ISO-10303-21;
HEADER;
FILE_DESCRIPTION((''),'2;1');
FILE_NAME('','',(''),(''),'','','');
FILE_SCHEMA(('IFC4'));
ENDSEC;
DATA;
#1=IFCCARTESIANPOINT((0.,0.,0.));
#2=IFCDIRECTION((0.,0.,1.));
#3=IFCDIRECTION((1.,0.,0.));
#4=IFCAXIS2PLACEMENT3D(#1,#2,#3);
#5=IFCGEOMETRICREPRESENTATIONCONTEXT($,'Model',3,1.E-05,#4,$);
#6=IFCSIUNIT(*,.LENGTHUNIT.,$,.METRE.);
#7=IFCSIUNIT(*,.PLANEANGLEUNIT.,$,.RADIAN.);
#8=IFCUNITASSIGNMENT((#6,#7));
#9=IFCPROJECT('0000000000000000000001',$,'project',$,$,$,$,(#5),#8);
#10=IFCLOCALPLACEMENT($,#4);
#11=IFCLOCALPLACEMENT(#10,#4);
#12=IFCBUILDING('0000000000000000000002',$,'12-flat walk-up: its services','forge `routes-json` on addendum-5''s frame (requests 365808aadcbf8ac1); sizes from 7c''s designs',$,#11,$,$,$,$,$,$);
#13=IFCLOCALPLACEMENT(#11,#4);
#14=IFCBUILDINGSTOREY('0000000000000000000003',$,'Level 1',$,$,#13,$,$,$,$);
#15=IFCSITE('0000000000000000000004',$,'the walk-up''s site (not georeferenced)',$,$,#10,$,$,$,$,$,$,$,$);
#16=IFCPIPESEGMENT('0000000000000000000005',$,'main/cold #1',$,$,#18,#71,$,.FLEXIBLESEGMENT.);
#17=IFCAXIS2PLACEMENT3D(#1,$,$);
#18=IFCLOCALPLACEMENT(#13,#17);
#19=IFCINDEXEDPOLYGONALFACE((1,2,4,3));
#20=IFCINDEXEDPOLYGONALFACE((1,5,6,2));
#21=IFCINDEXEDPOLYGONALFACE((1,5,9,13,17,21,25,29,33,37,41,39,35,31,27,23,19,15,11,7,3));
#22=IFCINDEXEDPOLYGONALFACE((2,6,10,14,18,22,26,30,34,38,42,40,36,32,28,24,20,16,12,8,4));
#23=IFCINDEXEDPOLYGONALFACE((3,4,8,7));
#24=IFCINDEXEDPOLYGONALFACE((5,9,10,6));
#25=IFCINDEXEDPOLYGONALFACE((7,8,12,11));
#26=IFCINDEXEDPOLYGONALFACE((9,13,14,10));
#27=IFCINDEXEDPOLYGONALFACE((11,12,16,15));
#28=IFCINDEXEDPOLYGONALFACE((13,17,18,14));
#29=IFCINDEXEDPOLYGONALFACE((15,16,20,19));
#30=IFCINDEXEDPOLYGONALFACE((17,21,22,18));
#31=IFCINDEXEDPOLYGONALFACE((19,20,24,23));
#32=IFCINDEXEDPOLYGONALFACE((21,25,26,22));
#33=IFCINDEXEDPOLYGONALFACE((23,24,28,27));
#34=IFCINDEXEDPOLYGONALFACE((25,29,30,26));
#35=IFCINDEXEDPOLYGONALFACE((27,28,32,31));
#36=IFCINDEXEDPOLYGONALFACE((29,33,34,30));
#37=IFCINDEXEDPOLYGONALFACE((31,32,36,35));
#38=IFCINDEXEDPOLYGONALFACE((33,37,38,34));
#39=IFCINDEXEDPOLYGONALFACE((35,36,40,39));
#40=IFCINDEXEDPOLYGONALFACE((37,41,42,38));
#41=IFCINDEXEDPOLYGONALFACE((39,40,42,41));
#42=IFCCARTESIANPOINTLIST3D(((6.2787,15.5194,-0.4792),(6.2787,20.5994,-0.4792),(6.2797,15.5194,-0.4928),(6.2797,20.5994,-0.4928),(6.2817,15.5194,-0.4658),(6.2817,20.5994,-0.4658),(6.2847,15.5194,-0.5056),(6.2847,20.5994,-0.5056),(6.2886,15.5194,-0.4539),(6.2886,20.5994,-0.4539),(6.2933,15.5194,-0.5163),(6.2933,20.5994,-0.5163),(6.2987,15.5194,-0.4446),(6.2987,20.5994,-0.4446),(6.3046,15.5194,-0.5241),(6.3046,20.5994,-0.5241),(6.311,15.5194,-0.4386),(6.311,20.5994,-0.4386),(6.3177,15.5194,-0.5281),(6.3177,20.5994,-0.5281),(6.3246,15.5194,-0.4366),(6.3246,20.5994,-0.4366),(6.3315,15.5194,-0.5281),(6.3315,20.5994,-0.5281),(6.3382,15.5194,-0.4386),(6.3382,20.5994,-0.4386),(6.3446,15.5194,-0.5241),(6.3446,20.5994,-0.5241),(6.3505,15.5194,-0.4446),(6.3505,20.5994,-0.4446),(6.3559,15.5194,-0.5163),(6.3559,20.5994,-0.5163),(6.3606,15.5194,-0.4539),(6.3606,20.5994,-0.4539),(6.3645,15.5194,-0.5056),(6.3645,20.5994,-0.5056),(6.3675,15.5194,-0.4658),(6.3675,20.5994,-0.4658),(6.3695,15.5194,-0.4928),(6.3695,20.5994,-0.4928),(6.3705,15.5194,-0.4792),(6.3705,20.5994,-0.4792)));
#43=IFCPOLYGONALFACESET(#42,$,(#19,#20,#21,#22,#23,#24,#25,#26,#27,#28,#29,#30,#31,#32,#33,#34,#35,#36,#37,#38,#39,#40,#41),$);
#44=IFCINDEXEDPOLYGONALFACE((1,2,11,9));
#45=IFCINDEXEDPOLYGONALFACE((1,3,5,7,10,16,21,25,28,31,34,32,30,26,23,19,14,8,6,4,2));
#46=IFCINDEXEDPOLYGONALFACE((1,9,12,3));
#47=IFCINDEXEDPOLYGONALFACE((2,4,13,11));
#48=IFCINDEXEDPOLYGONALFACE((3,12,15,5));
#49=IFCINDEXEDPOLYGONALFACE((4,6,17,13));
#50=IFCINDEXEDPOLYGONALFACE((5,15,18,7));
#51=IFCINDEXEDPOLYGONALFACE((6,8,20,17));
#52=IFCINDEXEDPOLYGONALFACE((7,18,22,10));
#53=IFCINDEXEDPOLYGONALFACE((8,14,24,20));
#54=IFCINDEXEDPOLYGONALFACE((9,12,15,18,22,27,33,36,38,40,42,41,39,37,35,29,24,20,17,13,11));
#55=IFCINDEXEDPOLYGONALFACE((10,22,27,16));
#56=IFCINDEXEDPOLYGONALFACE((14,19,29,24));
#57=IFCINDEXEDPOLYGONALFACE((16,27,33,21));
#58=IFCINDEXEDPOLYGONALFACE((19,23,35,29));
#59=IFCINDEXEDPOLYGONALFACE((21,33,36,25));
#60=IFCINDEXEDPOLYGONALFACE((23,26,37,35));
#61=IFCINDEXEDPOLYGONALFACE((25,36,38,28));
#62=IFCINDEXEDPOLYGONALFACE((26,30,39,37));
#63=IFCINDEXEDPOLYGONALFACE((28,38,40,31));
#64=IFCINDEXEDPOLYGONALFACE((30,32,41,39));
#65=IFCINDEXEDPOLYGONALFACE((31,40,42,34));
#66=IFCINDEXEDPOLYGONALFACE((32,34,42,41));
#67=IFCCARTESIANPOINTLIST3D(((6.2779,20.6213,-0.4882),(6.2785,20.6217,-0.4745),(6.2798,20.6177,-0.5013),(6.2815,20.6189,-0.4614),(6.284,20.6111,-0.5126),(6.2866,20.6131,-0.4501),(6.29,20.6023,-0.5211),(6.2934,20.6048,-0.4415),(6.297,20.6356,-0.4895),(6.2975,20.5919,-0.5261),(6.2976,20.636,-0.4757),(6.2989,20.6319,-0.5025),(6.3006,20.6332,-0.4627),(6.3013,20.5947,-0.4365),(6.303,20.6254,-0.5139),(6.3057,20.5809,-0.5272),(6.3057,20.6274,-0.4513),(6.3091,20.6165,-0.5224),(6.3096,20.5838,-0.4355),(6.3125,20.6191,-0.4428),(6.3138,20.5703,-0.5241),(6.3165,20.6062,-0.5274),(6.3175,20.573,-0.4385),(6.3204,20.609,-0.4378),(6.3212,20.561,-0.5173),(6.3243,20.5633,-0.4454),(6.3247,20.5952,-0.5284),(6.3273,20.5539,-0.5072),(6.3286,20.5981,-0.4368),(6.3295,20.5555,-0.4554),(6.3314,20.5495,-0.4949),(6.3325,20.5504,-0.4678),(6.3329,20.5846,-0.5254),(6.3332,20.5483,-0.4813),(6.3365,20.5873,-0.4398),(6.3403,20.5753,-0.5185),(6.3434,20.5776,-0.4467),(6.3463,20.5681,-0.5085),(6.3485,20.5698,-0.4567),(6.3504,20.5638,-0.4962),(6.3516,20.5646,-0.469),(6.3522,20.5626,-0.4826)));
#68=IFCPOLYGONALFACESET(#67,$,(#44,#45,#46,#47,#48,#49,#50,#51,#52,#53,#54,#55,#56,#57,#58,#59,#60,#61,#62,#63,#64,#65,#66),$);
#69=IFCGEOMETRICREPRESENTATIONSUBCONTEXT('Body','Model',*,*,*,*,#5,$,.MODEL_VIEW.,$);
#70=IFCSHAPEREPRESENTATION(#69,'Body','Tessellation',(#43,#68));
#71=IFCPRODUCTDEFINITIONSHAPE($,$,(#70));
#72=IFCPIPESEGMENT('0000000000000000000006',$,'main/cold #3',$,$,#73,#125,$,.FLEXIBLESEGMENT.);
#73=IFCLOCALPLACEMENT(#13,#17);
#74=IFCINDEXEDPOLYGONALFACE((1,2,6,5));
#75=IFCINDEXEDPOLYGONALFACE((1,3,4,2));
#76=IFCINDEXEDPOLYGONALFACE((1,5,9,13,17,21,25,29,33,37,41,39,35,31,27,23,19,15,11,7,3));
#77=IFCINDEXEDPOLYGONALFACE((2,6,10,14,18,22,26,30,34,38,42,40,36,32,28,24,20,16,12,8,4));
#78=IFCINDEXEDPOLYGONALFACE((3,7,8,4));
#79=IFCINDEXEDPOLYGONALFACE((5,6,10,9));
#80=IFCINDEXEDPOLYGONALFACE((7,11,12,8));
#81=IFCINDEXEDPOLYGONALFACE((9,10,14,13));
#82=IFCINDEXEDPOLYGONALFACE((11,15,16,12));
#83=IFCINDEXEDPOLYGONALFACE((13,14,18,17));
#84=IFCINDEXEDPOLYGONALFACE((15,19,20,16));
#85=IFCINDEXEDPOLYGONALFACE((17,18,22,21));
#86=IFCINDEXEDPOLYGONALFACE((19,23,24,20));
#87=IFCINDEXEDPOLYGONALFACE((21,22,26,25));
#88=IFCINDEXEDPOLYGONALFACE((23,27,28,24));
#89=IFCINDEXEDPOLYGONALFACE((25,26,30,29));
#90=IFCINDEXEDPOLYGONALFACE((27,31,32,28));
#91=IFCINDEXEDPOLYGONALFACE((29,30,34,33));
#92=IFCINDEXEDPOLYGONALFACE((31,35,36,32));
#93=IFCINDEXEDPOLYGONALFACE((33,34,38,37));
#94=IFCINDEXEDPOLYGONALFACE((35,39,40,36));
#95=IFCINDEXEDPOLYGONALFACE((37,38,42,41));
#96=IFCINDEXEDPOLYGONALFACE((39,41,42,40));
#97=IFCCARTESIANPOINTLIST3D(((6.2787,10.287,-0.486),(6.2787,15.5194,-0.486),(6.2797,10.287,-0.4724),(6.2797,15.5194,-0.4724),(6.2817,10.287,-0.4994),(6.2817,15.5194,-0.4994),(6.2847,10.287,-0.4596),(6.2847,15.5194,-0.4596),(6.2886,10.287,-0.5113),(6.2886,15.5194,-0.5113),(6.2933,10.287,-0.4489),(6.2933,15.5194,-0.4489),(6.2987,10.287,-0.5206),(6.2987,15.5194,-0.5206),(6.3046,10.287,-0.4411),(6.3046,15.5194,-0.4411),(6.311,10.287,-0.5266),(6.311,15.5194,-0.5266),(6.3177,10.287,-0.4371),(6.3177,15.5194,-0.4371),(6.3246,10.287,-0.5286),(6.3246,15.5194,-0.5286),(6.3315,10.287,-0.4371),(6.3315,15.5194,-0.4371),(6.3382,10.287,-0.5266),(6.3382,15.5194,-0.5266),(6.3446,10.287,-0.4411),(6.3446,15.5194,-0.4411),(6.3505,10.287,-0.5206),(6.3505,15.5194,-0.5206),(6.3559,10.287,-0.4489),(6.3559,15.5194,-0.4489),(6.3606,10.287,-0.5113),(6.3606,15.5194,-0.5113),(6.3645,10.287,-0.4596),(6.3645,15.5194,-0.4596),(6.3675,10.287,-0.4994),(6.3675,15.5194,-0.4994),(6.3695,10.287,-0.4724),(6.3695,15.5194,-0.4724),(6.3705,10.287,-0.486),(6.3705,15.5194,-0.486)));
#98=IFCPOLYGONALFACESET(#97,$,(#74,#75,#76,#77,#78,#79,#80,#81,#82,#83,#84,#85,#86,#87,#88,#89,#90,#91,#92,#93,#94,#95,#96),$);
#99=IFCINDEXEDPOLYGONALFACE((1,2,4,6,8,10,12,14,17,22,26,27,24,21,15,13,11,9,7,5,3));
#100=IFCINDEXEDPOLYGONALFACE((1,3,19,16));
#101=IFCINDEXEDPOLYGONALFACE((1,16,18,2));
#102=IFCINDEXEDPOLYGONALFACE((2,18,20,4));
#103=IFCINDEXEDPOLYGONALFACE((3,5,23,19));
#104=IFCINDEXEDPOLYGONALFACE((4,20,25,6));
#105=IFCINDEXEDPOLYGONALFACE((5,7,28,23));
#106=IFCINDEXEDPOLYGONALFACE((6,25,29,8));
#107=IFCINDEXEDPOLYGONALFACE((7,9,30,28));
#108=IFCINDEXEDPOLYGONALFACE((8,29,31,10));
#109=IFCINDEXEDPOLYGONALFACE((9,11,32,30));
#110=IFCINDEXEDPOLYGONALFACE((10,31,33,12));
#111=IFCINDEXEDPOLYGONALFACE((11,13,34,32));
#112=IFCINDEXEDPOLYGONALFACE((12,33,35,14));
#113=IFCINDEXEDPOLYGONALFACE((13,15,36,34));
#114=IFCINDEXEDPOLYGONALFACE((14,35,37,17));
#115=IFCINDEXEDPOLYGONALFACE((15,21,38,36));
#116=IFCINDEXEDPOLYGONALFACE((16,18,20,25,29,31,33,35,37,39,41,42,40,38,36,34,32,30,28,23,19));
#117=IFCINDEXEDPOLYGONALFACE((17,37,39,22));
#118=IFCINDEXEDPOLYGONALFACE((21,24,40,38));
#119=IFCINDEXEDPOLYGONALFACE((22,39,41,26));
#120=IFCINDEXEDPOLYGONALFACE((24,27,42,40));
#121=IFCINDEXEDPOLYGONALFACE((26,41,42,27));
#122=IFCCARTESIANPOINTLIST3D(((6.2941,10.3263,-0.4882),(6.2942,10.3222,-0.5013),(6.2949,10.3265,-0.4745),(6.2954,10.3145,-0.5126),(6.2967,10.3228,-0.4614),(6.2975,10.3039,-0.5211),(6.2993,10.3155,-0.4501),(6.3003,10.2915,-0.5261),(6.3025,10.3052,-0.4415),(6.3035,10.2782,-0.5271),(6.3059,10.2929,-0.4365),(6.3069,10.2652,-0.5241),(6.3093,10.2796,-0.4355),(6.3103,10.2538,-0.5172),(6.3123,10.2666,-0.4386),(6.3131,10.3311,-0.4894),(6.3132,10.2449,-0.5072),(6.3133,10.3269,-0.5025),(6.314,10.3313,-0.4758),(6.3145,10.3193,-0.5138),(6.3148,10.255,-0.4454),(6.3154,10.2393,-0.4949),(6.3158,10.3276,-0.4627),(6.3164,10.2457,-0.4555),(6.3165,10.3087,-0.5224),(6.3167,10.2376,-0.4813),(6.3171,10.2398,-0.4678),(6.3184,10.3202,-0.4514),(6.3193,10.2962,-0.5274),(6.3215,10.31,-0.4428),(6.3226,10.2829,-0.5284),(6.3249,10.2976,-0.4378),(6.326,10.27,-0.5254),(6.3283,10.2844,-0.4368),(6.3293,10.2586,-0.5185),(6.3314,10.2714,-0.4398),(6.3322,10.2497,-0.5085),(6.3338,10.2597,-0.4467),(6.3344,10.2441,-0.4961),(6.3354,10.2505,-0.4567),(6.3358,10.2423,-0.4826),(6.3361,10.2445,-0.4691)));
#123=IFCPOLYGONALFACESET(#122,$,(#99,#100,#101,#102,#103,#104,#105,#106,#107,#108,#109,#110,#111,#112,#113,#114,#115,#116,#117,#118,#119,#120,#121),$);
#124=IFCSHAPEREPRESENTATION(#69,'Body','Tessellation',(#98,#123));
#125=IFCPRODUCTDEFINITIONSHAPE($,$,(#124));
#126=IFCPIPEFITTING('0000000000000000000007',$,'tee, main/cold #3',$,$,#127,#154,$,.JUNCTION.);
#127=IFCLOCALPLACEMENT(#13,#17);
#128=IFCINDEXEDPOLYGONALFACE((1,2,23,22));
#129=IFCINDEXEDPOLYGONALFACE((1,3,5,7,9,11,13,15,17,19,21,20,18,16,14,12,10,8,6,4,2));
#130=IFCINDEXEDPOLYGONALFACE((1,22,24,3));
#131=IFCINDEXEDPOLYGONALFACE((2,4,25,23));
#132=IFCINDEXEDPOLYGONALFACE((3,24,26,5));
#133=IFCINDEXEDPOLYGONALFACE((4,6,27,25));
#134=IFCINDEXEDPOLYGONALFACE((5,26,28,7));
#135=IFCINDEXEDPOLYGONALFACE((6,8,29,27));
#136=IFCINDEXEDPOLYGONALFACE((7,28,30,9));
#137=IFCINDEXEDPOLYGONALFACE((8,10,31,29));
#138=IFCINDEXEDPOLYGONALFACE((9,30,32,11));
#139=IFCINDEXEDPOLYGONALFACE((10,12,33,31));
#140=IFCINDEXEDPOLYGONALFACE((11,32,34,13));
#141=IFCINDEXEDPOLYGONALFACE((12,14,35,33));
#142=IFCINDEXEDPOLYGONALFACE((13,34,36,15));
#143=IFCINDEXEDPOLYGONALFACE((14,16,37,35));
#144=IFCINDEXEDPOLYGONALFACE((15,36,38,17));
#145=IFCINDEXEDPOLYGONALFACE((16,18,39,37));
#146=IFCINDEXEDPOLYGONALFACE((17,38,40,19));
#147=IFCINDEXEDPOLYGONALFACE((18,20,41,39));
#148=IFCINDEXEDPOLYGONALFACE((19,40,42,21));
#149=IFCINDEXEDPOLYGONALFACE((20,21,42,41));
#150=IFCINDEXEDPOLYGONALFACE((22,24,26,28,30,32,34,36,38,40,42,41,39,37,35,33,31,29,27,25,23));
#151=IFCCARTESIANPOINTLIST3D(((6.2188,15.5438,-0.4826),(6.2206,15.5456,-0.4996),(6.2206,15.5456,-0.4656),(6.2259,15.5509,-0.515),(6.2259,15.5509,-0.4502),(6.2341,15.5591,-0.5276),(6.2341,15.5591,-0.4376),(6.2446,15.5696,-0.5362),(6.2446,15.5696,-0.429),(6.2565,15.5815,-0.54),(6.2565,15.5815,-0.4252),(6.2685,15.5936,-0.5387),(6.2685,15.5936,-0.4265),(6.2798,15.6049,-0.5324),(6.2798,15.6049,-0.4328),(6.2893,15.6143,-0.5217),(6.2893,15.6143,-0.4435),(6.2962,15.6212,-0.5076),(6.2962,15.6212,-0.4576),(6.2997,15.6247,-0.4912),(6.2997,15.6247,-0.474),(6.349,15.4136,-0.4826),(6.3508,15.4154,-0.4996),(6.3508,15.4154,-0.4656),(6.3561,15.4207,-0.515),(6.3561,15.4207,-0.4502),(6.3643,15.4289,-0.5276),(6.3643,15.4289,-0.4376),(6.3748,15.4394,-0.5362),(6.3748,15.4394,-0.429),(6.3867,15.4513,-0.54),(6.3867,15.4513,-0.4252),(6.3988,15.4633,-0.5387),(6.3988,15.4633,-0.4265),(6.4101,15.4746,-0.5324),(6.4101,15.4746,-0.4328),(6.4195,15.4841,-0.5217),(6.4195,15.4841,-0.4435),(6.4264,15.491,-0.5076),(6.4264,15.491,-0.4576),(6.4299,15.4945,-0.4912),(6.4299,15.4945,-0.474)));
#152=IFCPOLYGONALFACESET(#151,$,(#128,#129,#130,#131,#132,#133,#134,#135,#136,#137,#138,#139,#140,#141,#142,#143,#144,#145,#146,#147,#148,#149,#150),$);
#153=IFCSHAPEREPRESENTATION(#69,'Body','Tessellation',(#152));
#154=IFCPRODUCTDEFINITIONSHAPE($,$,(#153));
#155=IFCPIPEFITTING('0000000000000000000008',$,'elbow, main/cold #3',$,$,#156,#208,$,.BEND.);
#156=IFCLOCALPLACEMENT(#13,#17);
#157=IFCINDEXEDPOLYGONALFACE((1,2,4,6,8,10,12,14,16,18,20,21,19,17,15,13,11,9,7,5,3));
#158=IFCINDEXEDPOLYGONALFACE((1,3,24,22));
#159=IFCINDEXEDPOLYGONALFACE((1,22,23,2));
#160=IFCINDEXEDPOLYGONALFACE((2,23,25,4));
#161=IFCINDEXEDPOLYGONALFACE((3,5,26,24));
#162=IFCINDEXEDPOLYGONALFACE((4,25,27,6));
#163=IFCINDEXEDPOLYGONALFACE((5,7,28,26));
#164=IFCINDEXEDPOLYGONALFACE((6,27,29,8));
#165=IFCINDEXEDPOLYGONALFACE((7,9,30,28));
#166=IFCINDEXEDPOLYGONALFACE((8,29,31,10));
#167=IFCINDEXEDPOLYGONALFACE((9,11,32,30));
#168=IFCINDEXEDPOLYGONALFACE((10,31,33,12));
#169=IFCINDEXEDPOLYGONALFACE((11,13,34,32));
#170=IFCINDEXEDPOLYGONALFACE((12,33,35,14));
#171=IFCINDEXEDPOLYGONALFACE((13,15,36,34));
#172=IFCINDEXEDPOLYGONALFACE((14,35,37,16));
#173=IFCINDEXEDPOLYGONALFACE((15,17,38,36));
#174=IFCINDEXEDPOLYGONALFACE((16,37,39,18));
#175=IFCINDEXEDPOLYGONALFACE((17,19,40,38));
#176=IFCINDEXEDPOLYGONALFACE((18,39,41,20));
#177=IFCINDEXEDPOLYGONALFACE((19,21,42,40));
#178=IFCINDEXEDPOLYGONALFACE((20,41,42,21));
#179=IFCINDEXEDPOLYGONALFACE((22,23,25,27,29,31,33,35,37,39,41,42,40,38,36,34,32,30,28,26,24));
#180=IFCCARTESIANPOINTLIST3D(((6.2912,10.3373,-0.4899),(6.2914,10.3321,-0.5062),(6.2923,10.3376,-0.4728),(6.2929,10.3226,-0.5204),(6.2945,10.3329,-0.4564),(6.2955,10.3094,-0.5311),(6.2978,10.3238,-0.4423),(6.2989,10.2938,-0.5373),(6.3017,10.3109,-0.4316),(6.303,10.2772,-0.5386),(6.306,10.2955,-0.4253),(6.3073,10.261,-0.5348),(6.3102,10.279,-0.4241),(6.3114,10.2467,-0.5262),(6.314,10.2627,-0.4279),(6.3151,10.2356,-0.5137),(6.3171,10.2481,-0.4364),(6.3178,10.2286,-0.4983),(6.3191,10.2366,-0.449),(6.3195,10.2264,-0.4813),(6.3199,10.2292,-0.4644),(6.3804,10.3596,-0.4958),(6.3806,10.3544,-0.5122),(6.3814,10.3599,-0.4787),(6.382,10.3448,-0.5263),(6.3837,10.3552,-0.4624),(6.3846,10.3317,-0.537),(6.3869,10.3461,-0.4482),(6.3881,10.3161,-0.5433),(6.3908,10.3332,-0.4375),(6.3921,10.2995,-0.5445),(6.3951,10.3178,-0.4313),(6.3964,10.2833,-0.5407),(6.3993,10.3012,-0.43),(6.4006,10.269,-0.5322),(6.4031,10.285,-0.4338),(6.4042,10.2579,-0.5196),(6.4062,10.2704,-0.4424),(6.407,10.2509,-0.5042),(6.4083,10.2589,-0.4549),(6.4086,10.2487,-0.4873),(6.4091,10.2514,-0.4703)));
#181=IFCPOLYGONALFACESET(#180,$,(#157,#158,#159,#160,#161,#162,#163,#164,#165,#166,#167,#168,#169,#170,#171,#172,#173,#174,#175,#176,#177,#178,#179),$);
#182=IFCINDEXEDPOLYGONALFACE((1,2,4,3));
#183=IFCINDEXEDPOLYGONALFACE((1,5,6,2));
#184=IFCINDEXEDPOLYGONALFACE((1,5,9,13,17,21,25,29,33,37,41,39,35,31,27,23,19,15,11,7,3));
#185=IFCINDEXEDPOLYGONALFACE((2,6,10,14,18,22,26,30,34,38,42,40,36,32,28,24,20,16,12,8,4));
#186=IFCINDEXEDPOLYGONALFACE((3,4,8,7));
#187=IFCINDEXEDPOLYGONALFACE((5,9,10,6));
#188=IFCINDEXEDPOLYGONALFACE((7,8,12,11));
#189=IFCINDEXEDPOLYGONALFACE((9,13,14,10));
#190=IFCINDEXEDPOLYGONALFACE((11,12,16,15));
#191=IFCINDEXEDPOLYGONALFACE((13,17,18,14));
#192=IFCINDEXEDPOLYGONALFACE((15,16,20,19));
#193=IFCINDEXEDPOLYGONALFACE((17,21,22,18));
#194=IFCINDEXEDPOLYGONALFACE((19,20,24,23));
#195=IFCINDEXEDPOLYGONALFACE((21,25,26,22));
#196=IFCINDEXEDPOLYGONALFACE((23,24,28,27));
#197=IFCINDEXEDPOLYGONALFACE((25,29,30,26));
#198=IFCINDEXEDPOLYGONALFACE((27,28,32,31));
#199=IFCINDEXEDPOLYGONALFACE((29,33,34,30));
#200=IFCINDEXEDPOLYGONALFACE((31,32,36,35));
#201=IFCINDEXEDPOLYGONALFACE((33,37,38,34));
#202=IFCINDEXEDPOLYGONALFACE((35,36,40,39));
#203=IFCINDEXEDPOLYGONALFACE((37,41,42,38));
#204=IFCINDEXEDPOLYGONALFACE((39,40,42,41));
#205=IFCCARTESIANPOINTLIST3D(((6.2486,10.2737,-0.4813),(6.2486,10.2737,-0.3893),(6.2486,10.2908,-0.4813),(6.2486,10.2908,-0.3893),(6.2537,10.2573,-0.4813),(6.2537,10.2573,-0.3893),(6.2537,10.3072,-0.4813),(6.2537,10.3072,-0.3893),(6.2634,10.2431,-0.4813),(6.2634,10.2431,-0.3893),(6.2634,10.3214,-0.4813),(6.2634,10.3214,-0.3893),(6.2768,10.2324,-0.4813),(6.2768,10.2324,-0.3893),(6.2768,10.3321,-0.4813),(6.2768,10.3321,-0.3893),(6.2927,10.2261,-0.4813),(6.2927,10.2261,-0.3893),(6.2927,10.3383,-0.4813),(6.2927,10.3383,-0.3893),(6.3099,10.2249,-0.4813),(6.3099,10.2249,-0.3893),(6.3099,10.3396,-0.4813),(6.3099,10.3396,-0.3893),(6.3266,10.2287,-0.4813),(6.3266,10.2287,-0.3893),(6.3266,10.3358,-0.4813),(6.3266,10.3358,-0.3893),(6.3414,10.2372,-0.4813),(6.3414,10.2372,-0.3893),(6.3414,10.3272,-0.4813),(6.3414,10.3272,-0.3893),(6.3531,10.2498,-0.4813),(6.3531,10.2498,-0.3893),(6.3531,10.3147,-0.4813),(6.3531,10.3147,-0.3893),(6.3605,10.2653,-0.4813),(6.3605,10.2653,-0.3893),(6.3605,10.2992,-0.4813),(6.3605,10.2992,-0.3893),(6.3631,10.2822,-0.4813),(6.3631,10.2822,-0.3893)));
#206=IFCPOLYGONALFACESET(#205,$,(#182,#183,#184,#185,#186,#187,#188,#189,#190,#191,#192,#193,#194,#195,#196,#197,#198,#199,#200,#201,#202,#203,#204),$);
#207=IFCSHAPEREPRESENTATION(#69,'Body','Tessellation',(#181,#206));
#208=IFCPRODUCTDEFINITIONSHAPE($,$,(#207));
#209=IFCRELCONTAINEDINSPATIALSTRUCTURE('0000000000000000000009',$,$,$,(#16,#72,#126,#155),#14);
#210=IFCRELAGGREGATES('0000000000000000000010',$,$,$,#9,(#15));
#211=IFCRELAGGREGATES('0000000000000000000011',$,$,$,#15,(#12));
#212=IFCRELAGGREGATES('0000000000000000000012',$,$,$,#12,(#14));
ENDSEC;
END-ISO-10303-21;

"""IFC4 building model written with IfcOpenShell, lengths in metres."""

from ifc_helpers import new_model, entity, si_unit, frame, origin_with_axes, place, context, subcontext, project, spatial, element, save


model = new_model("IFC4")

# Units and contexts
model_context = context("Model", 3, precision=1e-05, world=origin_with_axes())
body_context = subcontext(model_context, "Body", "Model", "MODEL_VIEW")
ifc_project = project(units=[si_unit("LENGTHUNIT", "METRE"), si_unit("PLANEANGLEUNIT", "RADIAN")], contexts=[model_context])

# Site, building, storey
site_placement = place(None, origin_with_axes())
site = spatial("IfcSite", under=ifc_project, at=site_placement, Name="the walk-up's site (not georeferenced)")
building_placement = place(site_placement, origin_with_axes())
building = spatial("IfcBuilding", under=site, at=building_placement, Name="12-flat walk-up: its services", Description="forge `routes-json` on addendum-5's frame (requests 365808aadcbf8ac1); sizes from 7c's designs")
storey_placement = place(building_placement, origin_with_axes())
storey = spatial("IfcBuildingStorey", under=building, at=storey_placement, Name="Level 1")

# Pipe segments
pipe_segment_1_placement = place(storey_placement, frame((6.3246, 15.5194, -0.4826), z_axis=(0.0, 0.0, 1.0), x_axis=(1.0, 0.0, 0.0)))
element("IfcPipeSegment", 1, at=pipe_segment_1_placement, inside=storey, Name="main/cold #1", PredefinedType="FLEXIBLESEGMENT", context=body_context, shape_type="AdvancedSweptSolid", body=[
    entity("IfcSweptDiskSolid", entity("IfcPolyline", [entity("IfcCartesianPoint", [0.0, 0.0, 0.0]), entity("IfcCartesianPoint", [0.0, 5.08, 0.0])]), 0.046),
    entity("IfcSweptDiskSolid", entity("IfcPolyline", [entity("IfcCartesianPoint", [0.0, 5.08, 0.0]), entity("IfcCartesianPoint", [-0.019, 5.0657, 0.0013])]), 0.046),
])
pipe_segment_2_placement = place(storey_placement, frame((6.3246, 15.5194, -0.4826), z_axis=(0.0, 0.0, 1.0), x_axis=(1.0, 0.0, 0.0)))
element("IfcPipeSegment", 2, at=pipe_segment_2_placement, inside=storey, Name="main/cold #3", PredefinedType="FLEXIBLESEGMENT", context=body_context, shape_type="AdvancedSweptSolid", body=[
    entity("IfcSweptDiskSolid", entity("IfcPolyline", [entity("IfcCartesianPoint", [0.0, 0.0, 0.0]), entity("IfcCartesianPoint", [0.0, -5.2324, 0.0])]), 0.046),
    entity("IfcSweptDiskSolid", entity("IfcPolyline", [entity("IfcCartesianPoint", [0.0, -5.2324, 0.0]), entity("IfcCartesianPoint", [-0.019, -5.2372, 0.0013])]), 0.046),
])

# Pipe fittings
pipe_fitting_1_placement = place(storey_placement, frame((6.3897, 15.4543, -0.4826), z_axis=(0.0, 0.0, 1.0), x_axis=(1.0, 0.0, 0.0)))
element("IfcPipeFitting", 3, at=pipe_fitting_1_placement, inside=storey, Name="tee, main/cold #3", PredefinedType="JUNCTION", context=body_context, shape_type="AdvancedSweptSolid", body=[
    entity("IfcSweptDiskSolid", entity("IfcPolyline", [entity("IfcCartesianPoint", [0.0, 0.0, 0.0]), entity("IfcCartesianPoint", [-0.1302, 0.1302, 0.0])]), 0.0575),
])
pipe_fitting_2_placement = place(storey_placement, frame((6.3947, 10.3045, -0.4873), z_axis=(0.0, 0.0, 1.0), x_axis=(1.0, 0.0, 0.0)))
element("IfcPipeFitting", 4, at=pipe_fitting_2_placement, inside=storey, Name="elbow, main/cold #3", PredefinedType="BEND", context=body_context, shape_type="AdvancedSweptSolid", body=[
    entity("IfcSweptDiskSolid", entity("IfcPolyline", [entity("IfcCartesianPoint", [0.0, 0.0, 0.0]), entity("IfcCartesianPoint", [-0.0891, -0.0223, 0.0059])]), 0.0575),
    entity("IfcSweptDiskSolid", entity("IfcPolyline", [entity("IfcCartesianPoint", [-0.0891, -0.0223, 0.0059]), entity("IfcCartesianPoint", [-0.0891, -0.0223, 0.098])]), 0.0575),
])

save(model, "model.ifc")
